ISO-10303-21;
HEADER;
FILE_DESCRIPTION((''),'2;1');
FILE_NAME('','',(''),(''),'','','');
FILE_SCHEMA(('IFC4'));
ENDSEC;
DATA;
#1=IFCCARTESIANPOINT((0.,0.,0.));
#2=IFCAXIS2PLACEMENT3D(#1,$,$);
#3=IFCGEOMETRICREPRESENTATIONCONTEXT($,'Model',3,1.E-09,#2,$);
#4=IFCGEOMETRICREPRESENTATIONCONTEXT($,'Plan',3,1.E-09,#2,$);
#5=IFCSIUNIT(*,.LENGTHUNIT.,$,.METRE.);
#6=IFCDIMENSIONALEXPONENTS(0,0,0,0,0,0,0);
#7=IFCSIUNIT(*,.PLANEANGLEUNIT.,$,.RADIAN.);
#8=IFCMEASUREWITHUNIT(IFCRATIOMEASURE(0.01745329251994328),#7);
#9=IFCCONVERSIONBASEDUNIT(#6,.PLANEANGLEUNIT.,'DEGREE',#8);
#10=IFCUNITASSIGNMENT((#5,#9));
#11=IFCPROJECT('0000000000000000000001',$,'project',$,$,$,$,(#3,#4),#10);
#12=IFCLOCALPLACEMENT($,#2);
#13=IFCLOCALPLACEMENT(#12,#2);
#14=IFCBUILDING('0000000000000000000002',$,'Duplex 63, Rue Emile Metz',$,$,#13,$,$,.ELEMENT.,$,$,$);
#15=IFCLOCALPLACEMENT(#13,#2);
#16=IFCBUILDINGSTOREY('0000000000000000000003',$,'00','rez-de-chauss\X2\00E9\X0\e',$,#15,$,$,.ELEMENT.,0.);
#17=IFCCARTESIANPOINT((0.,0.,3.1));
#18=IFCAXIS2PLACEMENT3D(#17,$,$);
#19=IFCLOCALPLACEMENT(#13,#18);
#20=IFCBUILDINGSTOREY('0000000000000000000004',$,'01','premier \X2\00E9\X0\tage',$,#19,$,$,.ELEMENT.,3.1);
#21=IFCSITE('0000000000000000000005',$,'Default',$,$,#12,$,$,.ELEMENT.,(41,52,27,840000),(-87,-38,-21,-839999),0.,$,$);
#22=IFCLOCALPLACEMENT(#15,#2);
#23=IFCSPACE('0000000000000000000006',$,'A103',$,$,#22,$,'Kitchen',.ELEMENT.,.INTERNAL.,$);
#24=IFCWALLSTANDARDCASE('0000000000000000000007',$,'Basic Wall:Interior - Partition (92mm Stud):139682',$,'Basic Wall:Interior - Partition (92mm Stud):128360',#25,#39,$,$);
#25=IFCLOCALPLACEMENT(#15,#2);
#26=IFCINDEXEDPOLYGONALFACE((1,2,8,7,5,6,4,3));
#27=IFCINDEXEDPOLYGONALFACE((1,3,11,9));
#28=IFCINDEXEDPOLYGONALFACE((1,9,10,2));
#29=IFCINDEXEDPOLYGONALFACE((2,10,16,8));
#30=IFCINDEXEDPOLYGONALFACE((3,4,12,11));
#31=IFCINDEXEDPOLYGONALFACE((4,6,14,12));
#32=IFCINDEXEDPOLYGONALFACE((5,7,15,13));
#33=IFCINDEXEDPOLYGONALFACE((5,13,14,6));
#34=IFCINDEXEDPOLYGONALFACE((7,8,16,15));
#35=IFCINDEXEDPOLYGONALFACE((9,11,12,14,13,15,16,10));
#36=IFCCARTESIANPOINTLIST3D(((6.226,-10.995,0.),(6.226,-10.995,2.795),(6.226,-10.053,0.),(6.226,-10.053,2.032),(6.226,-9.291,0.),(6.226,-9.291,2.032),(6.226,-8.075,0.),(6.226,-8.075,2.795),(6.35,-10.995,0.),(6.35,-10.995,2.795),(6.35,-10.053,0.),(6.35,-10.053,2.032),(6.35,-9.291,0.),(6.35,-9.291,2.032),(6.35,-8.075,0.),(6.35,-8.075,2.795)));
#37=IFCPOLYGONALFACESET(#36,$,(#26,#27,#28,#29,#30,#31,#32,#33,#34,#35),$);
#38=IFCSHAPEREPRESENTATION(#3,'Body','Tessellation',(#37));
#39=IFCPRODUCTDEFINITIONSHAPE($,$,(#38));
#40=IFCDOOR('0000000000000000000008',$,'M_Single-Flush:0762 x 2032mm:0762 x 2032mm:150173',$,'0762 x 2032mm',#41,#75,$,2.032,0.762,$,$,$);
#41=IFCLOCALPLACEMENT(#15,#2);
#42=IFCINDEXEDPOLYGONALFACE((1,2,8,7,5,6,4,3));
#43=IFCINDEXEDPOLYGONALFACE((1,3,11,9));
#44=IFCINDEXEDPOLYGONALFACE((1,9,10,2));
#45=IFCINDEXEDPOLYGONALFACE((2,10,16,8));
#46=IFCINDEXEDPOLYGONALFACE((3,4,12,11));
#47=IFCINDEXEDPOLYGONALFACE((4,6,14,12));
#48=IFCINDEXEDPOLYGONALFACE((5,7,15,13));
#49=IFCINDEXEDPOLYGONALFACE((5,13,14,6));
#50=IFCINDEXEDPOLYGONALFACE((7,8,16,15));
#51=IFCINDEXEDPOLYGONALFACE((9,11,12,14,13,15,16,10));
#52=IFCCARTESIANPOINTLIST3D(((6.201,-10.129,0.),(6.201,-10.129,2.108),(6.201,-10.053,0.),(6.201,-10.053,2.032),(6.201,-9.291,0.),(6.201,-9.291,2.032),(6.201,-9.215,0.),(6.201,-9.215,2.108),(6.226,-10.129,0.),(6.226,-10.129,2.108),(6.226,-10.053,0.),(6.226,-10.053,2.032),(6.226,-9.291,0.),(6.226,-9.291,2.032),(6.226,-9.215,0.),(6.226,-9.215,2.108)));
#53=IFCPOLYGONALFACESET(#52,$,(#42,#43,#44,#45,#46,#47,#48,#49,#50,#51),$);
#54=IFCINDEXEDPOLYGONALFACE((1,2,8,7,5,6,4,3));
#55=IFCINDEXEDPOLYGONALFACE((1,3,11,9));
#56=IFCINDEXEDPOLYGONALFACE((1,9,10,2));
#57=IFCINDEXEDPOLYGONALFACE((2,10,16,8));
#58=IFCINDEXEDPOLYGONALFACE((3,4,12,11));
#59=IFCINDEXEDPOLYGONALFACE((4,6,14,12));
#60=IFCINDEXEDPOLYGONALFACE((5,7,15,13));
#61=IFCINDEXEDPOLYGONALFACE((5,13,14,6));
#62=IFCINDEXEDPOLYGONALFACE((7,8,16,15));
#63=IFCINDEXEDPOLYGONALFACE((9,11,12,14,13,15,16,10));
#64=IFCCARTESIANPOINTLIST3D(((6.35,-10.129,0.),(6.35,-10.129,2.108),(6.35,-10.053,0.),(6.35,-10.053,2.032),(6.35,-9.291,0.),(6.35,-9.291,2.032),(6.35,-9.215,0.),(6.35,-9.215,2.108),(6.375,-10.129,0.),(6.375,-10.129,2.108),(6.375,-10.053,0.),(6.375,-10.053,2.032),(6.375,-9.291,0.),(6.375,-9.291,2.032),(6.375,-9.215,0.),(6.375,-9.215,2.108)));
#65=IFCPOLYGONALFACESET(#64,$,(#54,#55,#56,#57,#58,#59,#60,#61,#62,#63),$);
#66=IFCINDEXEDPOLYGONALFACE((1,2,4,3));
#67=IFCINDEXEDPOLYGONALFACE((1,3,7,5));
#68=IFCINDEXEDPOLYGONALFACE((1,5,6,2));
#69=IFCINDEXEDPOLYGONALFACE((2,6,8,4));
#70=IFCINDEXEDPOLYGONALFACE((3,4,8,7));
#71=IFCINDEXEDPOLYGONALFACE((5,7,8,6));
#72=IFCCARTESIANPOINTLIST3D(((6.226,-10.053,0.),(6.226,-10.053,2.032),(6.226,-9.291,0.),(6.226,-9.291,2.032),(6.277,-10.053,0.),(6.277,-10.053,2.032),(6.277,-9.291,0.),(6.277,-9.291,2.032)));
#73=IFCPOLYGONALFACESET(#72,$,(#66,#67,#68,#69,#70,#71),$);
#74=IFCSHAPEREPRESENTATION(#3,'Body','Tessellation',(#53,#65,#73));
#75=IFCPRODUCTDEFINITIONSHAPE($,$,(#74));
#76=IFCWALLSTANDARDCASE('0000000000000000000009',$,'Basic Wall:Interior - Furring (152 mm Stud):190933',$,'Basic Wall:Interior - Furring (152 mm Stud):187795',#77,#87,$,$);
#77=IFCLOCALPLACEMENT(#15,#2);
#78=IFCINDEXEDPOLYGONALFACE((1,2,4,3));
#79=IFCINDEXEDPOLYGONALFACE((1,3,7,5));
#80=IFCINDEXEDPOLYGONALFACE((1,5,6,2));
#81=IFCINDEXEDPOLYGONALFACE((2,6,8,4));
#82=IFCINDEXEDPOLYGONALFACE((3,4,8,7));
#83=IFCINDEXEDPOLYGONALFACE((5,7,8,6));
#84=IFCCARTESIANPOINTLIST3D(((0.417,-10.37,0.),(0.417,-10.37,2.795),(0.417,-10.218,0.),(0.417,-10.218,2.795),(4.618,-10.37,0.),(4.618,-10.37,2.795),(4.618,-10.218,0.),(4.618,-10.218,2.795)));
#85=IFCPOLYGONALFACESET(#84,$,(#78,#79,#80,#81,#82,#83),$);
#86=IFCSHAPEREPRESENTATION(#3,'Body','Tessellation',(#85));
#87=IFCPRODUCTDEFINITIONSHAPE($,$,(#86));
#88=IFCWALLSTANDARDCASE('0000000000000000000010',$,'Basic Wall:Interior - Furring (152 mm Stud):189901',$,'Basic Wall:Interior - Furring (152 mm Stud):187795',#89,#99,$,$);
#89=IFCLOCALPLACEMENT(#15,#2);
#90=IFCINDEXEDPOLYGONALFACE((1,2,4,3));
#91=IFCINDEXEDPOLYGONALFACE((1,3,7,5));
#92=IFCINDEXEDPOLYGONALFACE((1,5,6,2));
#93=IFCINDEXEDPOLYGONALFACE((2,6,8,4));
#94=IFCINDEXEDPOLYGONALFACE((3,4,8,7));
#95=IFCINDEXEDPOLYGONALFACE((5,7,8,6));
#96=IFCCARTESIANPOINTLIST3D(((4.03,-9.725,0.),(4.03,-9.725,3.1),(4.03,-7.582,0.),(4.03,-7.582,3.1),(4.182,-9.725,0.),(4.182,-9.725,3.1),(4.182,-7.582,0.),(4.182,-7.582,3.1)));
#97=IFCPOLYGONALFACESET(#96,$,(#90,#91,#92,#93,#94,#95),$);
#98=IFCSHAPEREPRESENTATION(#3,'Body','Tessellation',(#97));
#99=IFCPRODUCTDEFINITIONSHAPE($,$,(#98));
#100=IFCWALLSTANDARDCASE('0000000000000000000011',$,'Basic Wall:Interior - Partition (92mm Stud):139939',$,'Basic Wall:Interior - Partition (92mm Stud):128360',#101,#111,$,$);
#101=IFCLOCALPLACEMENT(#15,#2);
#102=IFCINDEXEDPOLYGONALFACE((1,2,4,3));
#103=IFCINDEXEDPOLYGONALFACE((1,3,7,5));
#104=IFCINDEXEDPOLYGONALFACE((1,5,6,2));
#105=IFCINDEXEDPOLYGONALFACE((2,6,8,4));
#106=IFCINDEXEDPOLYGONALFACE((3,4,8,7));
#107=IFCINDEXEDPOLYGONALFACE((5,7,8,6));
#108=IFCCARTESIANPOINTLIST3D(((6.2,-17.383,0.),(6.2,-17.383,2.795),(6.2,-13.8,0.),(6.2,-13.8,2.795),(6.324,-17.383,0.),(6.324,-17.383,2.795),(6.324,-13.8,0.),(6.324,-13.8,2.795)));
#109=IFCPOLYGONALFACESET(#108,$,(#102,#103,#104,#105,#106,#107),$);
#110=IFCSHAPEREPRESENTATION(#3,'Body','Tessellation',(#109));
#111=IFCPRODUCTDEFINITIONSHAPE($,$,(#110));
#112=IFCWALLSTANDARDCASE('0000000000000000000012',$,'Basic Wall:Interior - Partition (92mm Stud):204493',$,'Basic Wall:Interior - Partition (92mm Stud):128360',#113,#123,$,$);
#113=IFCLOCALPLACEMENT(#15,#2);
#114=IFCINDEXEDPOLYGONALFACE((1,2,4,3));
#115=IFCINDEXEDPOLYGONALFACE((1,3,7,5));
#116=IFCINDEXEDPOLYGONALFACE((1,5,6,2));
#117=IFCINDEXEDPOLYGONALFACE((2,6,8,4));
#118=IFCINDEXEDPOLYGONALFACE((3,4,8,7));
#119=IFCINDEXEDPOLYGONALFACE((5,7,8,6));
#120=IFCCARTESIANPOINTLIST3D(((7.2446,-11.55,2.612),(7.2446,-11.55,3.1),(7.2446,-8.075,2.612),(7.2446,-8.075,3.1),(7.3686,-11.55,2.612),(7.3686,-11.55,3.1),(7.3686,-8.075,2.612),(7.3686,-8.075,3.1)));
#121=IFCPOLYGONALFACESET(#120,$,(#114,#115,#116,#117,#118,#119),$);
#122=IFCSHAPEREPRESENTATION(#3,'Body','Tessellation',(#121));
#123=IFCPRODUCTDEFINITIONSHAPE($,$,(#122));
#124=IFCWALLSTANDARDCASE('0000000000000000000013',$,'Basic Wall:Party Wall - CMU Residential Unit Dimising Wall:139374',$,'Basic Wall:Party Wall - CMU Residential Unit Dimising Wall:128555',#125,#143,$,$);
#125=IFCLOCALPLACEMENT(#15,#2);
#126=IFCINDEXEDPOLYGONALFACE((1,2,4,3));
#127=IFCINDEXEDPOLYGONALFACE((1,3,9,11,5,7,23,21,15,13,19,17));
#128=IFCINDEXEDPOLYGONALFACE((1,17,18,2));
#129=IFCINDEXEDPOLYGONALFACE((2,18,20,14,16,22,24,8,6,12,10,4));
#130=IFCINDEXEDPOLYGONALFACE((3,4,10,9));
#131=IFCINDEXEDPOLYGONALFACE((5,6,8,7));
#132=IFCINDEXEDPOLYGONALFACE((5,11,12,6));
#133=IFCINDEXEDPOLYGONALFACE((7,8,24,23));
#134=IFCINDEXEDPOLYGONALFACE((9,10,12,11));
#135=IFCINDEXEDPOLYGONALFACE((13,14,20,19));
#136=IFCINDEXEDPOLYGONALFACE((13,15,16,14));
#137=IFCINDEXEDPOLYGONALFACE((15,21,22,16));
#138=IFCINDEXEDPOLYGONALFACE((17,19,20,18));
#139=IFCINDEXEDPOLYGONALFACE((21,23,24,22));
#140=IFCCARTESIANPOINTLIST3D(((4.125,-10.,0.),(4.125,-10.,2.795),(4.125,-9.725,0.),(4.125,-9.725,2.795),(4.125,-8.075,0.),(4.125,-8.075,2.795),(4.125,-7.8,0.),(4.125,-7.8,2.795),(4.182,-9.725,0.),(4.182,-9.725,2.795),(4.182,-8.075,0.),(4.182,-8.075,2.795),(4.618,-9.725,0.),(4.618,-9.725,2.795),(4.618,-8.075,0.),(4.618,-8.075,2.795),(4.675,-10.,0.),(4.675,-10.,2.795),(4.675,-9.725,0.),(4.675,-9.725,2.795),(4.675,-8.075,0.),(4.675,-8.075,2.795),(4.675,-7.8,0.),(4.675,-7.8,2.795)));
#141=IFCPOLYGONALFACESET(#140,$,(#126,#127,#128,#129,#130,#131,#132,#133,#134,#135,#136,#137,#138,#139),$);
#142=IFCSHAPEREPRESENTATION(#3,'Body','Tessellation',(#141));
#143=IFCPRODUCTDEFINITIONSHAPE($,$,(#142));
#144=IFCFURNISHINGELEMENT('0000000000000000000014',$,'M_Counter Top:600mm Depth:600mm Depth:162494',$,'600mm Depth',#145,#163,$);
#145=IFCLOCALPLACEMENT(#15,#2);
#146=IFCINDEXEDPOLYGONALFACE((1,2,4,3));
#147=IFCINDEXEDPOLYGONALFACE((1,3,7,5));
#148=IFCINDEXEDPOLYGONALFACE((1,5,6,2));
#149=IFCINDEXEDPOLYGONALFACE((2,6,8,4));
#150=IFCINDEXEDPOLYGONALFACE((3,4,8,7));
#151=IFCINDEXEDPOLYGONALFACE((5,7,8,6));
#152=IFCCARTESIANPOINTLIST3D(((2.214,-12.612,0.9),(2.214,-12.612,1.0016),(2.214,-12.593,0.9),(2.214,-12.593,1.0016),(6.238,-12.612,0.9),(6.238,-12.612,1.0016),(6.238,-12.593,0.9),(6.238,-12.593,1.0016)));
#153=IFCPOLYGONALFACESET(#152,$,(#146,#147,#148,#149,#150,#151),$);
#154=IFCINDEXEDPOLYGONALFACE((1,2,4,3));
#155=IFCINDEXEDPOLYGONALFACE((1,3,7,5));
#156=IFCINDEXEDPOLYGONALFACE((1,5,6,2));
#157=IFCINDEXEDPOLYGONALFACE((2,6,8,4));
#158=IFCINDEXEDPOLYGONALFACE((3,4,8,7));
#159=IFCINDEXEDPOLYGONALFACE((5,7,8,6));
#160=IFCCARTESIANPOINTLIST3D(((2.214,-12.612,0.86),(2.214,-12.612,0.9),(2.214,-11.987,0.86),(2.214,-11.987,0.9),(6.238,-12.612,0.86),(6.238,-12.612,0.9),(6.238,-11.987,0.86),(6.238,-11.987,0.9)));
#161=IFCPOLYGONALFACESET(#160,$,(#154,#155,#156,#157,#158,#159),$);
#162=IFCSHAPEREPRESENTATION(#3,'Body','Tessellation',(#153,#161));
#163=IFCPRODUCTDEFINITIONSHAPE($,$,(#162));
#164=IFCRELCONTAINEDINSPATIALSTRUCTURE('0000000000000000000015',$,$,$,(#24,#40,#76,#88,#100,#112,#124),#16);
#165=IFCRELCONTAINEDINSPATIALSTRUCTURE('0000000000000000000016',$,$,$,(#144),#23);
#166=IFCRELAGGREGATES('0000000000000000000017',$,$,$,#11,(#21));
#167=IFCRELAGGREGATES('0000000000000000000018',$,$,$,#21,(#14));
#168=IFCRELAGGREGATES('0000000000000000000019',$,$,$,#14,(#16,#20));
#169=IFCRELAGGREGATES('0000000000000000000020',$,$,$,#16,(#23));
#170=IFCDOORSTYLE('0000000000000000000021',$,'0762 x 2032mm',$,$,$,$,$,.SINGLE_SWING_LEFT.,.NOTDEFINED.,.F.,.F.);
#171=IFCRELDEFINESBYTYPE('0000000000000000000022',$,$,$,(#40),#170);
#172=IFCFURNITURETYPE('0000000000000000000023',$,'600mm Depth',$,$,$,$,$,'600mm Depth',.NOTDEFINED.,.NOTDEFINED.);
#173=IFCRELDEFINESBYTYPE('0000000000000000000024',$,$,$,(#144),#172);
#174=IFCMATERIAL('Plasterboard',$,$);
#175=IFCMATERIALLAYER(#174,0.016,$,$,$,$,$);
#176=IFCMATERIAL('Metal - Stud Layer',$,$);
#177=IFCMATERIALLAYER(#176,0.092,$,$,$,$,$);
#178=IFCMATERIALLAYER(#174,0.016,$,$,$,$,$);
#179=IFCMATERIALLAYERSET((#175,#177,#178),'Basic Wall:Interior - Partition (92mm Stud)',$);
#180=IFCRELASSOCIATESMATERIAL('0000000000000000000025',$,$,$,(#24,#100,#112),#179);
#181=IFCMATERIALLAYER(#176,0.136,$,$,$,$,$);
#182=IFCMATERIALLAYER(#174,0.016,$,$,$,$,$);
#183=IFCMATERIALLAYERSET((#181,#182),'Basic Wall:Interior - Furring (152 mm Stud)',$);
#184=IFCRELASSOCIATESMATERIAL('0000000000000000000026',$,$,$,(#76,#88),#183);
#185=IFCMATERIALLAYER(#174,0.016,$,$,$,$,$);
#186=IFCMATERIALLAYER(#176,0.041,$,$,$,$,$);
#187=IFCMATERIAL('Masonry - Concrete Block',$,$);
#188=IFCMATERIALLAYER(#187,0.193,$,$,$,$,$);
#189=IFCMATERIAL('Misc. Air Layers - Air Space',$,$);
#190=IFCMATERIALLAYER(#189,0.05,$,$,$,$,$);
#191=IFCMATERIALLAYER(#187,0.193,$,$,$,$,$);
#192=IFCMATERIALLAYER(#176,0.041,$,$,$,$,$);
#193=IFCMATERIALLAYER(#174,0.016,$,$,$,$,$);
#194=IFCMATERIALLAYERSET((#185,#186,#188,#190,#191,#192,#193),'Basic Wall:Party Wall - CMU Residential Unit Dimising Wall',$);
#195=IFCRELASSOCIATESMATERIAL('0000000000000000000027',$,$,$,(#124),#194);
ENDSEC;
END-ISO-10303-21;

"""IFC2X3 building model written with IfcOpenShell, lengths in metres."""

from ifc_helpers import new_model, entity, si_unit, converted_unit, frame, frame_2d, origin, origin_2d_with_axis, place, context, project, spatial, polyline, rectangle, outline, extrude, clip, bounded_halfspace, source, transform, mapped, material, layer, layer_set, layer_usage, type_object, type_shapes, element, fill, save


model = new_model("IFC2X3")

# Units and contexts
model_context = context("Model", 3, precision=1e-09, world=origin())
plan_context = context("Plan", 3, precision=1e-09, world=origin())
ifc_project = project(units=[si_unit("LENGTHUNIT", "METRE"), converted_unit("PLANEANGLEUNIT", "DEGREE", entity("IfcRatioMeasure", 0.01745329251994328), si_unit("PLANEANGLEUNIT", "RADIAN"), dimensions=[0, 0, 0, 0, 0, 0, 0])], contexts=[model_context, plan_context])

# Site, building, storey
site_placement = place(None, origin())
site = spatial("IfcSite", under=ifc_project, at=site_placement, Name="Default", CompositionType="ELEMENT", RefLatitude=(41, 52, 27, 840000), RefLongitude=(-87, -38, -21, -839999), RefElevation=0.0)
building_placement = place(site_placement, origin())
building = spatial("IfcBuilding", under=site, at=building_placement, Name="Duplex 63, Rue Emile Metz", CompositionType="ELEMENT")
storey_1_placement = place(building_placement, origin())
storey_1 = spatial("IfcBuildingStorey", under=building, at=storey_1_placement, Name="00", Description="rez-de-chaussée", CompositionType="ELEMENT", Elevation=0.0)

# Shared definitions
ifc_material_1 = material(Name="Misc. Air Layers - Air Space")
ifc_material_2 = material(Name="Masonry - Concrete Block")
ifc_material_3 = material(Name="Metal - Stud Layer")
ifc_material_4 = material(Name="Plasterboard")

# Shared definitions
ifc_layer_1 = layer(ifc_material_4, 0.016)
ifc_layer_2 = layer(ifc_material_3, 0.041)
ifc_layer_3 = layer(ifc_material_2, 0.193)
ifc_layer_4 = layer(ifc_material_1, 0.05)
ifc_layer_5 = layer(ifc_material_2, 0.193)
ifc_layer_6 = layer(ifc_material_3, 0.041)
ifc_layer_7 = layer(ifc_material_4, 0.016)
ifc_layer_set_1 = layer_set([ifc_layer_1, ifc_layer_2, ifc_layer_3, ifc_layer_4, ifc_layer_5, ifc_layer_6, ifc_layer_7], Name="Basic Wall:Party Wall - CMU Residential Unit Dimising Wall")
ifc_layer_usage_1 = layer_usage(ifc_layer_set_1, "AXIS2", "NEGATIVE", 0.275)
ifc_layer_8 = layer(ifc_material_4, 0.016)
ifc_layer_9 = layer(ifc_material_3, 0.092)
ifc_layer_10 = layer(ifc_material_4, 0.016)
ifc_layer_set_2 = layer_set([ifc_layer_8, ifc_layer_9, ifc_layer_10], Name="Basic Wall:Interior - Partition (92mm Stud)")
ifc_layer_usage_2 = layer_usage(ifc_layer_set_2, "AXIS2", "NEGATIVE", 0.062)

# Shared definitions
storey_2_placement = place(building_placement, frame((0.0, 0.0, 3.1)))
storey_2 = spatial("IfcBuildingStorey", under=building, at=storey_2_placement, Name="01", Description="premier étage", CompositionType="ELEMENT", Elevation=3.1)

# Wall, opening, door
wall_1_placement = place(storey_1_placement, frame((6.288, -10.995, 0.0), z_axis=(0.0, 0.0, 1.0), x_axis=(0.0, 1.0, 0.0)))
wall_1 = element("IfcWallStandardCase", 1, at=wall_1_placement, inside=storey_1, material=ifc_layer_usage_2, Name="Basic Wall:Interior - Partition (92mm Stud):139682", ObjectType="Basic Wall:Interior - Partition (92mm Stud):128360", context=model_context, shape_type="SweptSolid", body=[
    extrude(rectangle(XDim=2.92, YDim=0.124, at=frame_2d((1.46, 0.0), x_axis=(-1.0, 0.0))), origin(), (0.0, 0.0, 1.0), 2.795),
])
opening_1_placement = place(wall_1_placement, frame((0.942, -0.062, 0.0)))
opening_1 = element("IfcOpeningElement", 2, at=opening_1_placement, cuts=wall_1, ObjectType="Opening", context=model_context, shape_type="SweptSolid", body=[
    extrude(rectangle(XDim=0.762, YDim=2.032, at=frame_2d((1.016, 0.381), x_axis=(0.0, -1.0))), frame((0.0, 0.0, 0.0), z_axis=(0.0, 1.0, 0.0), x_axis=(0.0, 0.0, 1.0)), (0.0, 0.0, 1.0), 0.124),
])
door_style_1 = type_object("IfcDoorStyle", Name="0762 x 2032mm", ConstructionType="NOTDEFINED", OperationType="SINGLE_SWING_LEFT", ParameterTakesPrecedence=False, Sizeable=False)
shared_shape_1 = source(origin(), model_context, "Body", "SweptSolid", [
    extrude(outline(polyline([(-0.457, -1.073), (0.457, -1.073), (0.457, 1.035), (0.381, 1.035), (0.381, -0.997), (-0.381, -0.997), (-0.381, 1.035), (-0.457, 1.035), (-0.457, -1.073)])), frame((0.381, 0.149, 1.035), z_axis=(0.0, -1.0, 0.0), x_axis=(-1.0, 0.0, 0.0)), (0.0, 0.0, 1.0), 0.025),
    extrude(outline(polyline([(-1.073, -0.457), (1.035, -0.457), (1.035, -0.381), (-0.997, -0.381), (-0.997, 0.381), (1.035, 0.381), (1.035, 0.457), (-1.073, 0.457), (-1.073, -0.457)])), frame((0.381, 0.0, 1.035), z_axis=(0.0, -1.0, 0.0), x_axis=(0.0, 0.0, -1.0)), (0.0, 0.0, 1.0), 0.025),
    extrude(rectangle(XDim=0.762, YDim=0.051, at=origin_2d_with_axis()), frame((0.381, 0.0985, 0.0)), (0.0, 0.0, 1.0), 2.032),
])
type_shapes(door_style_1, [shared_shape_1])
door_1_placement = place(opening_1_placement, origin())
door_1 = element("IfcDoor", 3, at=door_1_placement, inside=storey_1, type_object=door_style_1, Name="M_Single-Flush:0762 x 2032mm:0762 x 2032mm:150173", ObjectType="0762 x 2032mm", OverallHeight=2.032, OverallWidth=0.762, context=model_context, shape_type="MappedRepresentation", body=[
    mapped(shared_shape_1, transform((0.0, 0.0, 0.0), scale=1.0)),
])
fill(opening_1, door_1)

# Walls
ifc_layer_11 = layer(ifc_material_3, 0.136)
ifc_layer_12 = layer(ifc_material_4, 0.016)
ifc_layer_set_3 = layer_set([ifc_layer_11, ifc_layer_12], Name="Basic Wall:Interior - Furring (152 mm Stud)")
ifc_layer_usage_3 = layer_usage(ifc_layer_set_3, "AXIS2", "NEGATIVE", 0.076)
wall_2_placement = place(storey_1_placement, frame((0.417, -10.294, 0.0)))
element("IfcWallStandardCase", 4, at=wall_2_placement, inside=storey_1, material=ifc_layer_usage_3, Name="Basic Wall:Interior - Furring (152 mm Stud):190933", ObjectType="Basic Wall:Interior - Furring (152 mm Stud):187795", context=model_context, shape_type="SweptSolid", body=[
    extrude(rectangle(XDim=4.201, YDim=0.152, at=frame_2d((2.1005, 0.0), x_axis=(-1.0, 0.0))), origin(), (0.0, 0.0, 1.0), 2.795),
])
ifc_layer_usage_4 = layer_usage(ifc_layer_set_3, "AXIS2", "POSITIVE", -0.076)
wall_3_placement = place(storey_1_placement, frame((4.106, -9.725, 0.0), z_axis=(0.0, 0.0, 1.0), x_axis=(0.0, 1.0, 0.0)))
element("IfcWallStandardCase", 5, at=wall_3_placement, inside=storey_1, material=ifc_layer_usage_4, Name="Basic Wall:Interior - Furring (152 mm Stud):189901", ObjectType="Basic Wall:Interior - Furring (152 mm Stud):187795", context=model_context, shape_type="SweptSolid", body=[
    extrude(rectangle(XDim=2.143, YDim=0.152, at=frame_2d((1.0715, 0.0), x_axis=(-1.0, 0.0))), origin(), (0.0, 0.0, 1.0), 3.1),
])
wall_4_placement = place(storey_1_placement, frame((6.262, -13.8, 0.0), z_axis=(0.0, 0.0, 1.0), x_axis=(0.0, -1.0, 0.0)))
element("IfcWallStandardCase", 6, at=wall_4_placement, inside=storey_1, material=ifc_layer_usage_2, Name="Basic Wall:Interior - Partition (92mm Stud):139939", ObjectType="Basic Wall:Interior - Partition (92mm Stud):128360", context=model_context, shape_type="SweptSolid", body=[
    extrude(rectangle(XDim=3.583, YDim=0.124, at=frame_2d((1.7915, 0.0), x_axis=(-1.0, 0.0))), origin(), (0.0, 0.0, 1.0), 2.795),
])
wall_5_placement = place(storey_1_placement, frame((7.3066, -11.55, 2.612), z_axis=(0.0, 0.0, 1.0), x_axis=(0.0, 1.0, 0.0)))
element("IfcWallStandardCase", 7, at=wall_5_placement, inside=storey_1, material=ifc_layer_usage_2, Name="Basic Wall:Interior - Partition (92mm Stud):204493", ObjectType="Basic Wall:Interior - Partition (92mm Stud):128360", context=model_context, shape_type="SweptSolid", body=[
    extrude(rectangle(XDim=3.475, YDim=0.124, at=frame_2d((1.7375, 0.0), x_axis=(-1.0, 0.0))), origin(), (0.0, 0.0, 1.0), 0.488),
])
wall_6_placement = place(storey_1_placement, frame((4.4, -10.0, 0.0), z_axis=(0.0, 0.0, 1.0), x_axis=(0.0, 1.0, 0.0)))
element("IfcWallStandardCase", 8, at=wall_6_placement, inside=storey_1, material=ifc_layer_usage_1, Name="Basic Wall:Party Wall - CMU Residential Unit Dimising Wall:139374", ObjectType="Basic Wall:Party Wall - CMU Residential Unit Dimising Wall:128555", context=model_context, shape_type="Clipping", body=[
    clip(clip(extrude(rectangle(XDim=2.2, YDim=0.55, at=frame_2d((1.1, 0.0), x_axis=(-1.0, 0.0))), origin(), (0.0, 0.0, 1.0), 2.795), bounded_halfspace(frame((1.925, 0.218, 0.0), z_axis=(0.0, -1.0, 0.0), x_axis=(1.0, 0.0, 0.0)), True, frame((1.925, 0.218, 0.0), z_axis=(0.0, -1.0, 0.0), x_axis=(1.0, 0.0, 0.0)), polyline([(0.0, 0.0), (0.0, 2.795), (-1.65, 2.795), (-1.65, 0.0), (0.0, 0.0)]))), bounded_halfspace(frame((0.275, -0.218, 0.0), z_axis=(0.0, 1.0, 0.0), x_axis=(-1.0, 0.0, 0.0)), True, frame((0.275, -0.218, 0.0), z_axis=(0.0, 1.0, 0.0), x_axis=(-1.0, 0.0, 0.0)), polyline([(0.0, 0.0), (0.0, 2.795), (-1.65, 2.795), (-1.65, 0.0), (0.0, 0.0)]))),
])

# Shared definitions
space_1_placement = place(storey_1_placement, origin())
space_1 = spatial("IfcSpace", under=storey_1, at=space_1_placement, Name="A103", LongName="Kitchen", CompositionType="ELEMENT", InteriorOrExteriorSpace="INTERNAL")

# Furnishing element
furniture_type_1 = type_object("IfcFurnitureType", Name="600mm Depth", ElementType="600mm Depth", AssemblyPlace="NOTDEFINED")
shared_shape_2 = source(origin(), model_context, "Body", "SweptSolid", [
    extrude(rectangle(XDim=0.0191, YDim=4.024, at=origin_2d_with_axis()), frame((0.8115, -0.0095, 0.9), z_axis=(0.0, 0.0, 1.0), x_axis=(0.0, -1.0, 0.0)), (0.0, 0.0, 1.0), 0.1016),
    extrude(rectangle(XDim=4.024, YDim=0.625, at=origin_2d_with_axis()), frame((0.8115, -0.3125, 0.86), z_axis=(0.0, 0.0, 1.0), x_axis=(-1.0, 0.0, 0.0)), (0.0, 0.0, 1.0), 0.04),
])
type_shapes(furniture_type_1, [shared_shape_2])
furnishing_1_placement = place(space_1_placement, frame((5.0375, -12.612, 0.0), z_axis=(0.0, 0.0, 1.0), x_axis=(-1.0, 0.0, 0.0)))
element("IfcFurnishingElement", 9, at=furnishing_1_placement, inside=space_1, type_object=furniture_type_1, Name="M_Counter Top:600mm Depth:600mm Depth:162494", ObjectType="600mm Depth", context=model_context, shape_type="MappedRepresentation", body=[
    mapped(shared_shape_2, transform((0.0, 0.0, 0.0), scale=1.0)),
])

save(model, "model.ifc")
